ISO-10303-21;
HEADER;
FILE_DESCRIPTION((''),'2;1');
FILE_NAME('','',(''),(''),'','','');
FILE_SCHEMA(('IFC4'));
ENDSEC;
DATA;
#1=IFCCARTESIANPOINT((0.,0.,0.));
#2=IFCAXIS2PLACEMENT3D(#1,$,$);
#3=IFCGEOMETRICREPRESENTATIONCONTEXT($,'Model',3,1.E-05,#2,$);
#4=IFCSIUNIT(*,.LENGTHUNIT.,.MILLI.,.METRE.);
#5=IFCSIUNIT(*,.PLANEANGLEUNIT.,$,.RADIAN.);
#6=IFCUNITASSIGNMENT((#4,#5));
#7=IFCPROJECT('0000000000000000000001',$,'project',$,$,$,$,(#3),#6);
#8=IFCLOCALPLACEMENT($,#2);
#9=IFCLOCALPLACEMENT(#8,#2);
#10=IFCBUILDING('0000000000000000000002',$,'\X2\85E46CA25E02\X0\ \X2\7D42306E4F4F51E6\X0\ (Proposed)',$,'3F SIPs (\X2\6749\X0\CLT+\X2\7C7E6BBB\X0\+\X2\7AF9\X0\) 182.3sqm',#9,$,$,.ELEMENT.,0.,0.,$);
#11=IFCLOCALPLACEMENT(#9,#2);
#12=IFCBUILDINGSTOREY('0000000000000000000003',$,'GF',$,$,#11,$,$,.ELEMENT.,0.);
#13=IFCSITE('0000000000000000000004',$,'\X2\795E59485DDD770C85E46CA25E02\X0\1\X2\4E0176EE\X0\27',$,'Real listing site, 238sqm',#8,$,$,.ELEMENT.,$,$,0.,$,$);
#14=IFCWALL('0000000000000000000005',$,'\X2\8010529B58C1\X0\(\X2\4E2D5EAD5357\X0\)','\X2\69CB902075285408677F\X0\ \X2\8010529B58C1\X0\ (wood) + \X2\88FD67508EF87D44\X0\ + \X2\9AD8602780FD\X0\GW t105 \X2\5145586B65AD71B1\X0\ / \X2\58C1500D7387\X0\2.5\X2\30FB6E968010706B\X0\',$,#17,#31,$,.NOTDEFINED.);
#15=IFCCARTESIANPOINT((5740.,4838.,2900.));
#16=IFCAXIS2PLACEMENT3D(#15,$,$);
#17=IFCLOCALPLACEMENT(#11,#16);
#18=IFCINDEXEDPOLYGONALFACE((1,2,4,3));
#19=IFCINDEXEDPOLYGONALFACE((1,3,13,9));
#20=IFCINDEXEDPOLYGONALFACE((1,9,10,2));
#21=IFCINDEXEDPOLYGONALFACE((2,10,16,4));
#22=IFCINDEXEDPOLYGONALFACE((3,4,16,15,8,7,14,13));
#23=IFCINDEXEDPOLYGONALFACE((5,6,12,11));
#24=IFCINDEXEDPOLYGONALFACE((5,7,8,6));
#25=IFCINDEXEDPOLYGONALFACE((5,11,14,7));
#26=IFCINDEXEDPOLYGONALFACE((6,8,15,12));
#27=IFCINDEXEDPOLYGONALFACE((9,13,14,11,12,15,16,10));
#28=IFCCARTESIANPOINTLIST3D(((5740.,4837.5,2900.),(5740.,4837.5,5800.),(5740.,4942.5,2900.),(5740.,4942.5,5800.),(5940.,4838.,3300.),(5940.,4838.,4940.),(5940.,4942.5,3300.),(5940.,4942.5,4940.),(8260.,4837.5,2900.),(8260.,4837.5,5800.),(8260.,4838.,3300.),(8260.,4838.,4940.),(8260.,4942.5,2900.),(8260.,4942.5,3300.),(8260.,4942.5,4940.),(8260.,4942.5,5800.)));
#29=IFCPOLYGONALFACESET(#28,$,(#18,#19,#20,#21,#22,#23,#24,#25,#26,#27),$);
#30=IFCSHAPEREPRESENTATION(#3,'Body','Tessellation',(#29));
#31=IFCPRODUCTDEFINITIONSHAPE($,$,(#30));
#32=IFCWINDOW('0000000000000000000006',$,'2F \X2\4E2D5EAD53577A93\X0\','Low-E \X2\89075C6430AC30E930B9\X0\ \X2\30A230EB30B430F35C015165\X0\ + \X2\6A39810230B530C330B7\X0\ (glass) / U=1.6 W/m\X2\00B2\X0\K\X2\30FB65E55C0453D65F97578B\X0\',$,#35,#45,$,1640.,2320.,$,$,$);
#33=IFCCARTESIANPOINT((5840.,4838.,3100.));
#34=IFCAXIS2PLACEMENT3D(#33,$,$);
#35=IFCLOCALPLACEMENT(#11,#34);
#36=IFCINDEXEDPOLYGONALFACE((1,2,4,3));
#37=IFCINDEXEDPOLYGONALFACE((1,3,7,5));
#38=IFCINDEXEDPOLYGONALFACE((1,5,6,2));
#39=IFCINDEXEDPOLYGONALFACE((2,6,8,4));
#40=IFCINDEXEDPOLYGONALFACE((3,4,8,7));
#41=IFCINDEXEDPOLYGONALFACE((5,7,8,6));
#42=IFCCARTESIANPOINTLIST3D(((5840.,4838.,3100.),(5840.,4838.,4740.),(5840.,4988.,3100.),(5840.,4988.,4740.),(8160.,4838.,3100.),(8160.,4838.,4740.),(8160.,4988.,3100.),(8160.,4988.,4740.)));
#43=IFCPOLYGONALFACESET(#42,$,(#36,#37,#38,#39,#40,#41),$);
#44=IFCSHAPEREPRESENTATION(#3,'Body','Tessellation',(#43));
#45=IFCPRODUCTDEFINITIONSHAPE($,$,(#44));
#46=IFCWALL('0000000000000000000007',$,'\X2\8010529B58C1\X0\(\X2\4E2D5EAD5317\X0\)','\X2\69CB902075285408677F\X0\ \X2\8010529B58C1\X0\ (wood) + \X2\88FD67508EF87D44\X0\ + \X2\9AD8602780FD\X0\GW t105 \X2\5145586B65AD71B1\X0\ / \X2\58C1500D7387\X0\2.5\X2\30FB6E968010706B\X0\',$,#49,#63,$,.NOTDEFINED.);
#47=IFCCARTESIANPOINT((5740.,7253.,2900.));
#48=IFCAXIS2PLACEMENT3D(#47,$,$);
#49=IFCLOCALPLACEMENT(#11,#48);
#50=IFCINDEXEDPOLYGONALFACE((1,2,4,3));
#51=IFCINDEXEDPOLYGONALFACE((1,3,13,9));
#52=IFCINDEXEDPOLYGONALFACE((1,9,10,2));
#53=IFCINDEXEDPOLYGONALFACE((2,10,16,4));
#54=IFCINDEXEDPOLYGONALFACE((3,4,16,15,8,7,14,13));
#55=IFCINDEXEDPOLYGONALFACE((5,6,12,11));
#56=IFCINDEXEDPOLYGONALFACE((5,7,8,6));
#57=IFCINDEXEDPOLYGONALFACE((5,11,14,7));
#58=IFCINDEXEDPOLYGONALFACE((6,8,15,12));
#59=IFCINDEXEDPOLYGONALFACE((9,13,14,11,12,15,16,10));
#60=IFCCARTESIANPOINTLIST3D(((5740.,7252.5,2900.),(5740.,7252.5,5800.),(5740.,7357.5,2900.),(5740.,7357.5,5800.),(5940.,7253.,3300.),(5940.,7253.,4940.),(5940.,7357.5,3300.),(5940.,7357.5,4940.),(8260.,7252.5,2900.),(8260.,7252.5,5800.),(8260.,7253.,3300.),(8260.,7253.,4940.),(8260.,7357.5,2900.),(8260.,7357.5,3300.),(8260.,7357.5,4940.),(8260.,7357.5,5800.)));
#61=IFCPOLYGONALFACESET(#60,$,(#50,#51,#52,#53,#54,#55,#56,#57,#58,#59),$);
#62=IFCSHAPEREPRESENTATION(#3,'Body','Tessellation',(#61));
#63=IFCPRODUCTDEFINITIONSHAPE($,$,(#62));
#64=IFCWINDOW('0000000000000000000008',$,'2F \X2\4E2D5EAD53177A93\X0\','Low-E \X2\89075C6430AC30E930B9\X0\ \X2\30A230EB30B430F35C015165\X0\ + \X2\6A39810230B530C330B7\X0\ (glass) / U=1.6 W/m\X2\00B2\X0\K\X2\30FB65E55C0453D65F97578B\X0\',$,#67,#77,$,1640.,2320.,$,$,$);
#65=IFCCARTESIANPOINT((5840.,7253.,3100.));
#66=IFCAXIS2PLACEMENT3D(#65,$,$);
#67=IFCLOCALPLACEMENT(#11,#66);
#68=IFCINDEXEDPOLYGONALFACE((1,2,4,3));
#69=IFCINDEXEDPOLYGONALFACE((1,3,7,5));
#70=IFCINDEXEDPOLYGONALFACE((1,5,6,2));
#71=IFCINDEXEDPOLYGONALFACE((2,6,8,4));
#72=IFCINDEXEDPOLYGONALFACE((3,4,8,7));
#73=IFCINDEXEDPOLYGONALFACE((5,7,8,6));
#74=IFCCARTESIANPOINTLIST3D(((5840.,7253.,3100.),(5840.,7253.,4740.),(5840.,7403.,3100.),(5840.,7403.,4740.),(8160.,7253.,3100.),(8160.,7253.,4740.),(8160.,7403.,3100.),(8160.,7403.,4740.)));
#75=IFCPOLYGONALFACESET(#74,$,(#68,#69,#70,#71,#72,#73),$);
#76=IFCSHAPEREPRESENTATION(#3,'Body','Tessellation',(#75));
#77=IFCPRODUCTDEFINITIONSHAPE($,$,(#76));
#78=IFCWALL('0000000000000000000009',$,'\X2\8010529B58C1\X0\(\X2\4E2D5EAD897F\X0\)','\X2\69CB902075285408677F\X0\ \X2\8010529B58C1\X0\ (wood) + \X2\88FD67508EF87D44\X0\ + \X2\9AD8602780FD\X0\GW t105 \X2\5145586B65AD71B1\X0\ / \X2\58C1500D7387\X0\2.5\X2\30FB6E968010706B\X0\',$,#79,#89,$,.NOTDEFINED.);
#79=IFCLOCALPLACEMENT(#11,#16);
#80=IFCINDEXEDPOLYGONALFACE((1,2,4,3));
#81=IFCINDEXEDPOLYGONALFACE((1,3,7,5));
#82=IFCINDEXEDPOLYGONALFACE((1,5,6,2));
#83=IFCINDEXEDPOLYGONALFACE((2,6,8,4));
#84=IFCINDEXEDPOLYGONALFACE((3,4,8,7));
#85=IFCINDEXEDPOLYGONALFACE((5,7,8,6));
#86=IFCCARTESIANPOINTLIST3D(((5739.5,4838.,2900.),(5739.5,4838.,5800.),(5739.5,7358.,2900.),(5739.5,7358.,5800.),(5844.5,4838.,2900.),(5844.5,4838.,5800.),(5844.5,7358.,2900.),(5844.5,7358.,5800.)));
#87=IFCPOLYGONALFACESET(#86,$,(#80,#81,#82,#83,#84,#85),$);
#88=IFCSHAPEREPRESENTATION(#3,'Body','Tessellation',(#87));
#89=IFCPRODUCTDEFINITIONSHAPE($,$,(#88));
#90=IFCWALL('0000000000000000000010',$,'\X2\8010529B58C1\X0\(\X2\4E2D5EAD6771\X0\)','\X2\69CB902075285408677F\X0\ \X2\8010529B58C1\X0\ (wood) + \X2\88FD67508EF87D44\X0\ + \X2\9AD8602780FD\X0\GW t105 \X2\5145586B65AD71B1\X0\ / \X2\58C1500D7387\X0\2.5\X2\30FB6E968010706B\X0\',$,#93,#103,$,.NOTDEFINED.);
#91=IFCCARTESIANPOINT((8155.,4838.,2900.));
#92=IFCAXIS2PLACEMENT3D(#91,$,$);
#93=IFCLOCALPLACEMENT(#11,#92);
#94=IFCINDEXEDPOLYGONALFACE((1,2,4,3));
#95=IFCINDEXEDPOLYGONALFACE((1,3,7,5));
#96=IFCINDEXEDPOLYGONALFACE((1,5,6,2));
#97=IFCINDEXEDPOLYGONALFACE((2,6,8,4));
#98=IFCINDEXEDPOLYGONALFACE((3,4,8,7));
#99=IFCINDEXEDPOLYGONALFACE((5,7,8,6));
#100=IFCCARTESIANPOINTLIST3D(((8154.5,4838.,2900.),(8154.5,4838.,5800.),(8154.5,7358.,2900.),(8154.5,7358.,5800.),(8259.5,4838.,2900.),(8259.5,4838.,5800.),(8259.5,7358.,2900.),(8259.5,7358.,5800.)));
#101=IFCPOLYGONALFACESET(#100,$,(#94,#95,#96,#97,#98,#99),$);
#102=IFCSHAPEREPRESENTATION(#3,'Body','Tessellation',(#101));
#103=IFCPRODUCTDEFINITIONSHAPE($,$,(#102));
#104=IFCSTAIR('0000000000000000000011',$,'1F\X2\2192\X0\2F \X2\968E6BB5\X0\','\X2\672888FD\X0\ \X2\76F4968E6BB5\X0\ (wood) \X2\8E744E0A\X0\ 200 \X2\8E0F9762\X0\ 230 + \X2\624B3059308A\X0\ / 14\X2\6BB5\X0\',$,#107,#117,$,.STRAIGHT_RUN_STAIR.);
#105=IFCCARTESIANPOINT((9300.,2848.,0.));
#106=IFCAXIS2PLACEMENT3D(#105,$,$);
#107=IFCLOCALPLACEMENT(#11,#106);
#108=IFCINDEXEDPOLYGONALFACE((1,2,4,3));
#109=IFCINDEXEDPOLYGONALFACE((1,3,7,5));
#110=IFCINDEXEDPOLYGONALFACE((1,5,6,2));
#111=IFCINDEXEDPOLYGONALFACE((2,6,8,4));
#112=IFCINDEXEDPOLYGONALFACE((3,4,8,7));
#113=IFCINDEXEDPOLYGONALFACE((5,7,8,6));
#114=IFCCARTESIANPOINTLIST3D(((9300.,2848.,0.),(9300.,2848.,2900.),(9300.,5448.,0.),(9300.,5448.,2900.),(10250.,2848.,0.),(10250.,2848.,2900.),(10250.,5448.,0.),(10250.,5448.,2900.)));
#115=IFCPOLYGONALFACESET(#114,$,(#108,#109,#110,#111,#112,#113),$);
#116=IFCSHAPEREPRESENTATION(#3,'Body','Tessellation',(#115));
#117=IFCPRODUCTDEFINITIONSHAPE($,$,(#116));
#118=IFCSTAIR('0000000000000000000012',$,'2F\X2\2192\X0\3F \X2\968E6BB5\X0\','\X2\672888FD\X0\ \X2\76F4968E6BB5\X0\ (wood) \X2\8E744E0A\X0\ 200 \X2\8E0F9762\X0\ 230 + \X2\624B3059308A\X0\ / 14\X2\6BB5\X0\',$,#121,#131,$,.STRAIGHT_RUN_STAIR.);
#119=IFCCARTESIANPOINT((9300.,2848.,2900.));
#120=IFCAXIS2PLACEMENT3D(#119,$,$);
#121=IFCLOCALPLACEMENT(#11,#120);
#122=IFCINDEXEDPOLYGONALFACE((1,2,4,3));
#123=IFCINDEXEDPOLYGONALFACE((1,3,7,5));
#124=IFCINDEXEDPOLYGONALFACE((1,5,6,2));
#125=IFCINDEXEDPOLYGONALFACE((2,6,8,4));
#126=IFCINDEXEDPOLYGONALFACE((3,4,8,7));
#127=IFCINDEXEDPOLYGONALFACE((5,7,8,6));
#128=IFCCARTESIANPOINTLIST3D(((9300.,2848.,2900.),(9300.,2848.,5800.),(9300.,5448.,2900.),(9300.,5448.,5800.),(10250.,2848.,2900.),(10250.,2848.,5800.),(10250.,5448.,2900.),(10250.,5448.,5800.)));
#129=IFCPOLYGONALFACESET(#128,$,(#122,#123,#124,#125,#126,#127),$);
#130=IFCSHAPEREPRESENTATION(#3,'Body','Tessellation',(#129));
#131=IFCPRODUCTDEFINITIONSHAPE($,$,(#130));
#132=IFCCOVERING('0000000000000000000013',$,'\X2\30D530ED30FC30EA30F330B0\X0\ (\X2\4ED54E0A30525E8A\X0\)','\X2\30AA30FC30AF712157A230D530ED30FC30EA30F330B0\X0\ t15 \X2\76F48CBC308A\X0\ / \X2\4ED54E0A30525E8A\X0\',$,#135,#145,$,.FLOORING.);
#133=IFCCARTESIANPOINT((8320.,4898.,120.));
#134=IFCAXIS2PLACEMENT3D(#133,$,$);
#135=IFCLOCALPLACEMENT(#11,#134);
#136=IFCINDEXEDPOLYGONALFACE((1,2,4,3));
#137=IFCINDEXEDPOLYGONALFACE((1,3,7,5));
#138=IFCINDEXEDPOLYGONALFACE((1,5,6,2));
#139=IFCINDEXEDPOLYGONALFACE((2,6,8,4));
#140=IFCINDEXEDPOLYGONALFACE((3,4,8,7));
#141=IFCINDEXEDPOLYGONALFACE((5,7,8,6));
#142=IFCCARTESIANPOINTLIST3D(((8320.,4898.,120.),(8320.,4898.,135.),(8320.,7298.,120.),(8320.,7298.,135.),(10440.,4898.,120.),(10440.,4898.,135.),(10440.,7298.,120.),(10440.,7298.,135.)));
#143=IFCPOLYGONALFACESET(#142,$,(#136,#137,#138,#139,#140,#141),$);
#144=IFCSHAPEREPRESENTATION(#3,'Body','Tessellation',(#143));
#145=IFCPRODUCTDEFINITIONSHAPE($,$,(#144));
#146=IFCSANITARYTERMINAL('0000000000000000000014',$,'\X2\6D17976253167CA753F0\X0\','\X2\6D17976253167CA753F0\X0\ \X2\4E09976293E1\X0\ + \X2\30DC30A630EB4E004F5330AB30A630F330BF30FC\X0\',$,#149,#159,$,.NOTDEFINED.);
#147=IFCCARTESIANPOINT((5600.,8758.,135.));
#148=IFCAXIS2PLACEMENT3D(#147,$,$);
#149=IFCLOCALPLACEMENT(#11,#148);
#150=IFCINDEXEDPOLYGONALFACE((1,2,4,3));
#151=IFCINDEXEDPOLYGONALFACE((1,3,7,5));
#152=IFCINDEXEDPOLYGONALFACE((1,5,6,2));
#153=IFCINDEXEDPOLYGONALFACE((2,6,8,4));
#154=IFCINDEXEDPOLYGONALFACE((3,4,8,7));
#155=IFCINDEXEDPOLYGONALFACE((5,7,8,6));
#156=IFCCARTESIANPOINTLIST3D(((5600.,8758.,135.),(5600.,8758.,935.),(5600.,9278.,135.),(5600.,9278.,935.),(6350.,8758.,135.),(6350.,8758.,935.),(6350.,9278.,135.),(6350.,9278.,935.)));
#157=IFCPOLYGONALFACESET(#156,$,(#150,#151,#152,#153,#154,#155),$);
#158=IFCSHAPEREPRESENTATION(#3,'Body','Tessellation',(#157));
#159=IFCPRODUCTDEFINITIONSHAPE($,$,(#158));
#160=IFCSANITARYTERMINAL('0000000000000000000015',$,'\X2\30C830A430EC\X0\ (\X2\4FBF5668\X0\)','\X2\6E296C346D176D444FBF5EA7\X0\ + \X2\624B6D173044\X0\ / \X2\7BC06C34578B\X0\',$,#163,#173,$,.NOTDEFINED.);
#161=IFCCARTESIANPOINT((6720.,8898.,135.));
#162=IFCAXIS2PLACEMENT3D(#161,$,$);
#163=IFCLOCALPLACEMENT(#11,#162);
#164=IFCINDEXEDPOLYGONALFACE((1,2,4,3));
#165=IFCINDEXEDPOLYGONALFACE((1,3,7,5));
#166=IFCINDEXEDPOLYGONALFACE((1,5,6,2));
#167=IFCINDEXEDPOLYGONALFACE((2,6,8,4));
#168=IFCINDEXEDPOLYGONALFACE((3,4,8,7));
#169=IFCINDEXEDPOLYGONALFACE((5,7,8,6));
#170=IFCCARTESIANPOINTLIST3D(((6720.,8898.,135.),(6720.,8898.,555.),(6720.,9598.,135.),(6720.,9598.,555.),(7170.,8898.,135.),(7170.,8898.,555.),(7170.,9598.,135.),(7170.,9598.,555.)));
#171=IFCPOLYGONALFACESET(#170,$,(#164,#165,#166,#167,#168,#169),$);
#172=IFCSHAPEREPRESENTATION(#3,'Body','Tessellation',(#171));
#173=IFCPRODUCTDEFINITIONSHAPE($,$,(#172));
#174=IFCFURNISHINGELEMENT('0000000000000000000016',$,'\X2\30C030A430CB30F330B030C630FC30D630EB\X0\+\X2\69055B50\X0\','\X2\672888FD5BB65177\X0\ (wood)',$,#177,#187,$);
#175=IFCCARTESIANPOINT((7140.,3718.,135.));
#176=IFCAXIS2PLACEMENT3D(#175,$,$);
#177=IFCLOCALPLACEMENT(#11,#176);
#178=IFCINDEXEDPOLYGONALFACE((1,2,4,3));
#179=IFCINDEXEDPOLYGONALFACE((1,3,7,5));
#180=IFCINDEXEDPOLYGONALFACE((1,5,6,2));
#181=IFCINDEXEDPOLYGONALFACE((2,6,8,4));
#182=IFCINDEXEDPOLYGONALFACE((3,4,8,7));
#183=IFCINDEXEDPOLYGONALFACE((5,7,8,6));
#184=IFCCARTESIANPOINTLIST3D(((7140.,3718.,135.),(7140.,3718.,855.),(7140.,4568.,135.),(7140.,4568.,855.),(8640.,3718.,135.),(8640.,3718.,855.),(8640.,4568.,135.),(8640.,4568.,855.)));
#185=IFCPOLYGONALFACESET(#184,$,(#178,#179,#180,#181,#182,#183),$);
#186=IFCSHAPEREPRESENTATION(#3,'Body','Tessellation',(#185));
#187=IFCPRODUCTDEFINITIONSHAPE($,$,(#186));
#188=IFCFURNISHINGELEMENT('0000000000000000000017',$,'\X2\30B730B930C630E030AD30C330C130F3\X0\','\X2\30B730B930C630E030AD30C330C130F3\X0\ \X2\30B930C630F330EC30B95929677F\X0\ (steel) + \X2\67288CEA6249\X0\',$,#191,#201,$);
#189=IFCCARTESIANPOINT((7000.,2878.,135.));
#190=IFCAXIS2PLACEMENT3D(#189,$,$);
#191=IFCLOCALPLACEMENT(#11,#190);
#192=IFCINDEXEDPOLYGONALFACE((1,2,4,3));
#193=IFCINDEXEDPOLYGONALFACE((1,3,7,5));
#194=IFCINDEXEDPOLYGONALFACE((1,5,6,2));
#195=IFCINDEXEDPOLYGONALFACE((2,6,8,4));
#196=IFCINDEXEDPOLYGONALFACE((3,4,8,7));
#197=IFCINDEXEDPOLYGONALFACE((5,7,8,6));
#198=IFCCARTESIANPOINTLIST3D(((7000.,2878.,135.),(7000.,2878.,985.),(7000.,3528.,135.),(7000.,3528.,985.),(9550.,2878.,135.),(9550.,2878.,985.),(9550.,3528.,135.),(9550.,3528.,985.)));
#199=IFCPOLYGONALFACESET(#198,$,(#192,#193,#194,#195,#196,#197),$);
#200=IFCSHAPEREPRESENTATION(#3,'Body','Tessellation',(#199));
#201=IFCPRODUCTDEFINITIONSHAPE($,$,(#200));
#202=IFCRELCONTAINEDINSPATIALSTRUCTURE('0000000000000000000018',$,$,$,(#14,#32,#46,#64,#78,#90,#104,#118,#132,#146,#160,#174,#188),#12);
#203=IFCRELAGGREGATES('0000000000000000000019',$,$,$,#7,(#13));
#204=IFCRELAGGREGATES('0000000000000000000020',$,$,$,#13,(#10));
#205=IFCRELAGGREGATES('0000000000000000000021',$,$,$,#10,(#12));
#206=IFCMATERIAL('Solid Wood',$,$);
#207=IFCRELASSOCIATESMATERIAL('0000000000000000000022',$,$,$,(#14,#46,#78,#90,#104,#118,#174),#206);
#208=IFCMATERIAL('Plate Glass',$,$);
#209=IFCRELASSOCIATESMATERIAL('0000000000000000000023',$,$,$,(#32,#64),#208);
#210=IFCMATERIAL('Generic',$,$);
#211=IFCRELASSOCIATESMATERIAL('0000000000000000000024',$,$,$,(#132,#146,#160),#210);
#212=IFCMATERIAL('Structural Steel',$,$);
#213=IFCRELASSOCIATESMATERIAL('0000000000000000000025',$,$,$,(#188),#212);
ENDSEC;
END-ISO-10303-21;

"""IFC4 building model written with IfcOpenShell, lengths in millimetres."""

from ifc_helpers import new_model, si_unit, frame, frame_2d, origin, place, context, project, spatial, rectangle, extrude, material, element, fill, save


model = new_model("IFC4")

# Units and contexts
model_context = context("Model", 3, precision=1e-05, world=origin())
ifc_project = project(units=[si_unit("LENGTHUNIT", "METRE", prefix="MILLI"), si_unit("PLANEANGLEUNIT", "RADIAN")], contexts=[model_context])

# Site, building, storey
site_placement = place(None, origin())
site = spatial("IfcSite", under=ifc_project, at=site_placement, Name="神奈川県藤沢市1丁目27", ObjectType="Real listing site, 238sqm", CompositionType="ELEMENT", RefElevation=0.0)
building_placement = place(site_placement, origin())
building = spatial("IfcBuilding", under=site, at=building_placement, Name="藤沢市 終の住処 (Proposed)", ObjectType="3F SIPs (杉CLT+籾殻+竹) 182.3sqm", CompositionType="ELEMENT", ElevationOfRefHeight=0.0, ElevationOfTerrain=0.0)
storey_placement = place(building_placement, origin())
storey = spatial("IfcBuildingStorey", under=building, at=storey_placement, Name="GF", CompositionType="ELEMENT", Elevation=0.0)

# Shared definitions
ifc_material_1 = material(Name="Solid Wood")

# Shared definitions
ifc_material_2 = material(Name="Plate Glass")

# Walls, openings, windows
wall_1_placement = place(storey_placement, frame((5740.0, 4838.0, 2900.0)))
wall_1 = element("IfcWall", 1, at=wall_1_placement, inside=storey, material=ifc_material_1, Name="耐力壁(中庭南)", Description="構造用合板 耐力壁 (wood) + 製材軸組 + 高性能GW t105 充填断熱 / 壁倍率2.5・準耐火", PredefinedType="NOTDEFINED", context=model_context, shape_type="SweptSolid", body=[
    extrude(rectangle(XDim=2520.0, YDim=105.0, at=frame_2d((1260.0, 52.0))), frame((5740.0, 4838.0, 2900.0)), (0.0, 0.0, 1.0), 2900.0),
])
opening_1_placement = place(storey_placement, frame((5840.0, 4838.0, 3100.0)))
opening_1 = element("IfcOpeningElement", 2, at=opening_1_placement, cuts=wall_1, PredefinedType="NOTDEFINED", context=model_context, shape_type="SweptSolid", body=[
    extrude(rectangle(XDim=2320.0, YDim=150.0, at=frame_2d((1160.0, 75.0))), frame((5840.0, 4838.0, 3100.0)), (0.0, 0.0, 1.0), 1640.0),
])
window_1_placement = place(storey_placement, frame((5840.0, 4838.0, 3100.0)))
window_1 = element("IfcWindow", 3, at=window_1_placement, inside=storey, material=ifc_material_2, Name="2F 中庭南窓", Description="Low-E 複層ガラス アルゴン封入 + 樹脂サッシ (glass) / U=1.6 W/m²K・日射取得型", OverallHeight=1640.0, OverallWidth=2320.0, context=model_context, shape_type="SweptSolid", body=[
    extrude(rectangle(XDim=2320.0, YDim=150.0, at=frame_2d((1160.0, 75.0))), frame((5840.0, 4838.0, 3100.0)), (0.0, 0.0, 1.0), 1640.0),
])
fill(opening_1, window_1)
wall_2_placement = place(storey_placement, frame((5740.0, 7253.0, 2900.0)))
wall_2 = element("IfcWall", 4, at=wall_2_placement, inside=storey, material=ifc_material_1, Name="耐力壁(中庭北)", Description="構造用合板 耐力壁 (wood) + 製材軸組 + 高性能GW t105 充填断熱 / 壁倍率2.5・準耐火", PredefinedType="NOTDEFINED", context=model_context, shape_type="SweptSolid", body=[
    extrude(rectangle(XDim=2520.0, YDim=105.0, at=frame_2d((1260.0, 52.0))), frame((5740.0, 7253.0, 2900.0)), (0.0, 0.0, 1.0), 2900.0),
])
opening_2_placement = place(storey_placement, frame((5840.0, 7253.0, 3100.0)))
opening_2 = element("IfcOpeningElement", 5, at=opening_2_placement, cuts=wall_2, PredefinedType="NOTDEFINED", context=model_context, shape_type="SweptSolid", body=[
    extrude(rectangle(XDim=2320.0, YDim=150.0, at=frame_2d((1160.0, 75.0))), frame((5840.0, 7253.0, 3100.0)), (0.0, 0.0, 1.0), 1640.0),
])
window_2_placement = place(storey_placement, frame((5840.0, 7253.0, 3100.0)))
window_2 = element("IfcWindow", 6, at=window_2_placement, inside=storey, material=ifc_material_2, Name="2F 中庭北窓", Description="Low-E 複層ガラス アルゴン封入 + 樹脂サッシ (glass) / U=1.6 W/m²K・日射取得型", OverallHeight=1640.0, OverallWidth=2320.0, context=model_context, shape_type="SweptSolid", body=[
    extrude(rectangle(XDim=2320.0, YDim=150.0, at=frame_2d((1160.0, 75.0))), frame((5840.0, 7253.0, 3100.0)), (0.0, 0.0, 1.0), 1640.0),
])
fill(opening_2, window_2)

# Walls
wall_3_placement = place(storey_placement, frame((5740.0, 4838.0, 2900.0)))
element("IfcWall", 7, at=wall_3_placement, inside=storey, material=ifc_material_1, Name="耐力壁(中庭西)", Description="構造用合板 耐力壁 (wood) + 製材軸組 + 高性能GW t105 充填断熱 / 壁倍率2.5・準耐火", PredefinedType="NOTDEFINED", context=model_context, shape_type="SweptSolid", body=[
    extrude(rectangle(XDim=105.0, YDim=2520.0, at=frame_2d((52.0, 1260.0))), frame((5740.0, 4838.0, 2900.0)), (0.0, 0.0, 1.0), 2900.0),
])
wall_4_placement = place(storey_placement, frame((8155.0, 4838.0, 2900.0)))
element("IfcWall", 8, at=wall_4_placement, inside=storey, material=ifc_material_1, Name="耐力壁(中庭東)", Description="構造用合板 耐力壁 (wood) + 製材軸組 + 高性能GW t105 充填断熱 / 壁倍率2.5・準耐火", PredefinedType="NOTDEFINED", context=model_context, shape_type="SweptSolid", body=[
    extrude(rectangle(XDim=105.0, YDim=2520.0, at=frame_2d((52.0, 1260.0))), frame((8155.0, 4838.0, 2900.0)), (0.0, 0.0, 1.0), 2900.0),
])

# Stairs
stair_1_placement = place(storey_placement, frame((9300.0, 2848.0, 0.0)))
element("IfcStair", 9, at=stair_1_placement, inside=storey, material=ifc_material_1, Name="1F→2F 階段", Description="木製 直階段 (wood) 蹴上 200 踏面 230 + 手すり / 14段", PredefinedType="STRAIGHT_RUN_STAIR", context=model_context, shape_type="SweptSolid", body=[
    extrude(rectangle(XDim=950.0, YDim=2600.0, at=frame_2d((475.0, 1300.0))), frame((9300.0, 2848.0, 0.0)), (0.0, 0.0, 1.0), 2900.0),
])
stair_2_placement = place(storey_placement, frame((9300.0, 2848.0, 2900.0)))
element("IfcStair", 10, at=stair_2_placement, inside=storey, material=ifc_material_1, Name="2F→3F 階段", Description="木製 直階段 (wood) 蹴上 200 踏面 230 + 手すり / 14段", PredefinedType="STRAIGHT_RUN_STAIR", context=model_context, shape_type="SweptSolid", body=[
    extrude(rectangle(XDim=950.0, YDim=2600.0, at=frame_2d((475.0, 1300.0))), frame((9300.0, 2848.0, 2900.0)), (0.0, 0.0, 1.0), 2900.0),
])

# Covering
ifc_material_3 = material(Name="Generic")
covering_placement = place(storey_placement, frame((8320.0, 4898.0, 120.0)))
element("IfcCovering", 11, at=covering_placement, inside=storey, material=ifc_material_3, Name="フローリング (仕上げ床)", Description="オーク無垢フローリング t15 直貼り / 仕上げ床", PredefinedType="FLOORING", context=model_context, shape_type="SweptSolid", body=[
    extrude(rectangle(XDim=2120.0, YDim=2400.0, at=frame_2d((1060.0, 1200.0))), frame((8320.0, 4898.0, 120.0)), (0.0, 0.0, 1.0), 15.0),
])

# Sanitary terminals
sanitary_terminal_1_placement = place(storey_placement, frame((5600.0, 8758.0, 135.0)))
element("IfcSanitaryTerminal", 12, at=sanitary_terminal_1_placement, inside=storey, material=ifc_material_3, Name="洗面化粧台", Description="洗面化粧台 三面鏡 + ボウル一体カウンター", PredefinedType="NOTDEFINED", context=model_context, shape_type="SweptSolid", body=[
    extrude(rectangle(XDim=750.0, YDim=520.0, at=frame_2d((375.0, 260.0))), frame((5600.0, 8758.0, 135.0)), (0.0, 0.0, 1.0), 800.0),
])
sanitary_terminal_2_placement = place(storey_placement, frame((6720.0, 8898.0, 135.0)))
element("IfcSanitaryTerminal", 13, at=sanitary_terminal_2_placement, inside=storey, material=ifc_material_3, Name="トイレ (便器)", Description="温水洗浄便座 + 手洗い / 節水型", PredefinedType="NOTDEFINED", context=model_context, shape_type="SweptSolid", body=[
    extrude(rectangle(XDim=450.0, YDim=700.0, at=frame_2d((225.0, 350.0))), frame((6720.0, 8898.0, 135.0)), (0.0, 0.0, 1.0), 420.0),
])

# Furnishing elements
furnishing_1_placement = place(storey_placement, frame((7140.0, 3718.0, 135.0)))
element("IfcFurnishingElement", 14, at=furnishing_1_placement, inside=storey, material=ifc_material_1, Name="ダイニングテーブル+椅子", Description="木製家具 (wood)", context=model_context, shape_type="SweptSolid", body=[
    extrude(rectangle(XDim=1500.0, YDim=850.0, at=frame_2d((750.0, 425.0))), frame((7140.0, 3718.0, 135.0)), (0.0, 0.0, 1.0), 720.0),
])
ifc_material_4 = material(Name="Structural Steel")
furnishing_2_placement = place(storey_placement, frame((7000.0, 2878.0, 135.0)))
element("IfcFurnishingElement", 15, at=furnishing_2_placement, inside=storey, material=ifc_material_4, Name="システムキッチン", Description="システムキッチン ステンレス天板 (steel) + 木質扉", context=model_context, shape_type="SweptSolid", body=[
    extrude(rectangle(XDim=2550.0, YDim=650.0, at=frame_2d((1275.0, 325.0))), frame((7000.0, 2878.0, 135.0)), (0.0, 0.0, 1.0), 850.0),
])

save(model, "model.ifc")
